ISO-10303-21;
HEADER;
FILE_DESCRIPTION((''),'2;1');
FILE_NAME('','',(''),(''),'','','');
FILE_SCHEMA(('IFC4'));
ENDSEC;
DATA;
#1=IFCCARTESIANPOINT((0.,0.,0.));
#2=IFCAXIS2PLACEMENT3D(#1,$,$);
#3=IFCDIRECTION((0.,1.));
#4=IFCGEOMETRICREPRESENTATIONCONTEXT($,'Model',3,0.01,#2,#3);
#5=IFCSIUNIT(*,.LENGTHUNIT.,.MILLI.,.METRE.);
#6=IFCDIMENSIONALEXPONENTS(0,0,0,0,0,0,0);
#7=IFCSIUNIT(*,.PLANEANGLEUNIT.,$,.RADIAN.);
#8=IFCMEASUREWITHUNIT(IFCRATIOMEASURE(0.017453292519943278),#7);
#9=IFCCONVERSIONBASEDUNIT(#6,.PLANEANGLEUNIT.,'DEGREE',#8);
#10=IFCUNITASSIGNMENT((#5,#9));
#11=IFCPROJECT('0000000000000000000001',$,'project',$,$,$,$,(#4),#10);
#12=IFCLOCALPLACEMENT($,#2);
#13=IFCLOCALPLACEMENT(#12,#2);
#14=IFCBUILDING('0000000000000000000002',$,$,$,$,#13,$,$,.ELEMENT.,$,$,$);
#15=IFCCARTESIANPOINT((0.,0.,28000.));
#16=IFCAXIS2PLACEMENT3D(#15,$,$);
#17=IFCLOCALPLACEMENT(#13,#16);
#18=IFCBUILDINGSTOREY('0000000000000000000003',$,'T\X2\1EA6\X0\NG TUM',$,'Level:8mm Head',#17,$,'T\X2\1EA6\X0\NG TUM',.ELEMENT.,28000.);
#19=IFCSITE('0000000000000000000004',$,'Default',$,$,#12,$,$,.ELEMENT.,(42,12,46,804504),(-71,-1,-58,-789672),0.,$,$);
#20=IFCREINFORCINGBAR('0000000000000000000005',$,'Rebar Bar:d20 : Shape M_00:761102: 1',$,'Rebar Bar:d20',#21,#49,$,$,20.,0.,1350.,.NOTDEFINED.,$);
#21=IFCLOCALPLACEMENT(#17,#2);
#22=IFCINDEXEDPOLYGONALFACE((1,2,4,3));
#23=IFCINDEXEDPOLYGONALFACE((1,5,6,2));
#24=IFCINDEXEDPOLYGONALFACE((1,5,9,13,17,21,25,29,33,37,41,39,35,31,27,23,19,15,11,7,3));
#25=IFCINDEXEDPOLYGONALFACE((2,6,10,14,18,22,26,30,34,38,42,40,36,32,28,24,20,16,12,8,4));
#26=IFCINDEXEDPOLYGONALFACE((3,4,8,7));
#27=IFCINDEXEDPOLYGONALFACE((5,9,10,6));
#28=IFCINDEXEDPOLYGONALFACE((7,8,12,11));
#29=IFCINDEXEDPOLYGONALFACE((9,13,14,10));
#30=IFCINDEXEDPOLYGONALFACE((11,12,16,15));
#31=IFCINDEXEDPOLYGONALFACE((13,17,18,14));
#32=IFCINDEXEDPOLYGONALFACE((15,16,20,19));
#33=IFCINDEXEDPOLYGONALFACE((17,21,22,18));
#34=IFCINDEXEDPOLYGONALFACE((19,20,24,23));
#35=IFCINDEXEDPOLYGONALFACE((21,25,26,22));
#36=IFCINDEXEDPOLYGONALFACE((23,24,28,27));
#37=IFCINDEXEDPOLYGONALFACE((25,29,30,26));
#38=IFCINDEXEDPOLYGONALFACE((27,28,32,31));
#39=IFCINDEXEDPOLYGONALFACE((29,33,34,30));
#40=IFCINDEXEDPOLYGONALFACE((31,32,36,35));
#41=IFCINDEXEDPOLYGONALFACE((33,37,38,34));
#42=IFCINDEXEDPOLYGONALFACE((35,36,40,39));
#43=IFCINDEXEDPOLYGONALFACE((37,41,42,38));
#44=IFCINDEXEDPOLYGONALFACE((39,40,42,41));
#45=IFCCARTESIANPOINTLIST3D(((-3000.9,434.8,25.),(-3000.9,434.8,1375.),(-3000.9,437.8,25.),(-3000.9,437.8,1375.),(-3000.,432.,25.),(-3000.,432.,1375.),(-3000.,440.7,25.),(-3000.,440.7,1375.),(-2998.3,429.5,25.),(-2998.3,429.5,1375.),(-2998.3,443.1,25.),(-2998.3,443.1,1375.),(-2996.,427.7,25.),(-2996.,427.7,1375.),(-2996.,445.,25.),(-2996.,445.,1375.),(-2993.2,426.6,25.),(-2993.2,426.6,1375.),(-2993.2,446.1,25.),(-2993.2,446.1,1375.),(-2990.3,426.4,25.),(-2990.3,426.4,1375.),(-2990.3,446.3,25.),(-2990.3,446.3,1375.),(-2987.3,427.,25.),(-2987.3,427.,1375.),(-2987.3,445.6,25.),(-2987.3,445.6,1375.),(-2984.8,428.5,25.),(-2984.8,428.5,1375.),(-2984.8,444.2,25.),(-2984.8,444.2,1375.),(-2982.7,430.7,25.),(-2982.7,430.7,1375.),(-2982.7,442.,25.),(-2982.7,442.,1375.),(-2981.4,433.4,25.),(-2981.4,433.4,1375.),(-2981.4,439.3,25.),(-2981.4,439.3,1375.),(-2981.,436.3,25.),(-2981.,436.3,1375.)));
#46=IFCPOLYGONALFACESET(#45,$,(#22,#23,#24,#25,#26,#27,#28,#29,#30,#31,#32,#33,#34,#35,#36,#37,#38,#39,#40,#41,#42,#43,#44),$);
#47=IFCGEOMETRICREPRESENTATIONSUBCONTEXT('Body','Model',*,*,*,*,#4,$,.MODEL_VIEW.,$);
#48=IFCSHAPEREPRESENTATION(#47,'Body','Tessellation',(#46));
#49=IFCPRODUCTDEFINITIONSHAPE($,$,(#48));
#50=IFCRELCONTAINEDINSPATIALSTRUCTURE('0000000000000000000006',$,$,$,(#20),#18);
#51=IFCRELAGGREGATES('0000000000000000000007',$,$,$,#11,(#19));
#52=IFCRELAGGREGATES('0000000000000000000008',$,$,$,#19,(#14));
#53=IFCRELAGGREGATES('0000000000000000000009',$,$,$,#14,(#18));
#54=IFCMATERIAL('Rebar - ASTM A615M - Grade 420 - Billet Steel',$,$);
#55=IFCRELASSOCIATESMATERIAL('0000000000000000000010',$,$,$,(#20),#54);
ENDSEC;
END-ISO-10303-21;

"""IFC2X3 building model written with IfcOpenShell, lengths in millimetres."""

from ifc_helpers import new_model, entity, si_unit, converted_unit, direction, frame, origin, place, context, subcontext, project, spatial, material, element, save


model = new_model("IFC2X3")

# Units and contexts
model_context = context("Model", 3, precision=0.01, world=origin(), true_north=direction((0.0, 1.0)))
body_context = subcontext(model_context, "Body", "Model", "MODEL_VIEW")
ifc_project = project(units=[si_unit("LENGTHUNIT", "METRE", prefix="MILLI"), converted_unit("PLANEANGLEUNIT", "DEGREE", entity("IfcRatioMeasure", 0.017453292519943278), si_unit("PLANEANGLEUNIT", "RADIAN"), dimensions=[0, 0, 0, 0, 0, 0, 0])], contexts=[model_context])

# Site, building, storey
site_placement = place(None, origin())
site = spatial("IfcSite", under=ifc_project, at=site_placement, Name="Default", CompositionType="ELEMENT", RefLatitude=(42, 12, 46, 804504), RefLongitude=(-71, -1, -58, -789672), RefElevation=0.0)
building_placement = place(site_placement, origin())
building = spatial("IfcBuilding", under=site, at=building_placement, CompositionType="ELEMENT")
storey_placement = place(building_placement, frame((0.0, 0.0, 28000.0)))
storey = spatial("IfcBuildingStorey", under=building, at=storey_placement, Name="TẦNG TUM", ObjectType="Level:8mm Head", LongName="TẦNG TUM", CompositionType="ELEMENT", Elevation=28000.0)

# Reinforcing bar
ifc_material = material(Name="Rebar - ASTM A615M - Grade 420 - Billet Steel")
reinforcing_bar_1_placement = place(storey_placement, origin())
element("IfcReinforcingBar", 1, at=reinforcing_bar_1_placement, inside=storey, material=ifc_material, Name="Rebar Bar:d20 : Shape M_00:761102: 1", ObjectType="Rebar Bar:d20", BarLength=1350.0, BarRole="NOTDEFINED", CrossSectionArea=0.0, NominalDiameter=20.0, context=body_context, shape_type="AdvancedSweptSolid", body=[
    entity("IfcSweptDiskSolid", entity("IfcCompositeCurve", [entity("IfcCompositeCurveSegment", "CONTINUOUS", True, entity("IfcPolyline", [entity("IfcCartesianPoint", [-2991.0, 436.3, 25.0]), entity("IfcCartesianPoint", [-2991.0, 436.3, 1375.0])]))], False), 10.0, None, 0.0, 1.0),
])

save(model, "model.ifc")
